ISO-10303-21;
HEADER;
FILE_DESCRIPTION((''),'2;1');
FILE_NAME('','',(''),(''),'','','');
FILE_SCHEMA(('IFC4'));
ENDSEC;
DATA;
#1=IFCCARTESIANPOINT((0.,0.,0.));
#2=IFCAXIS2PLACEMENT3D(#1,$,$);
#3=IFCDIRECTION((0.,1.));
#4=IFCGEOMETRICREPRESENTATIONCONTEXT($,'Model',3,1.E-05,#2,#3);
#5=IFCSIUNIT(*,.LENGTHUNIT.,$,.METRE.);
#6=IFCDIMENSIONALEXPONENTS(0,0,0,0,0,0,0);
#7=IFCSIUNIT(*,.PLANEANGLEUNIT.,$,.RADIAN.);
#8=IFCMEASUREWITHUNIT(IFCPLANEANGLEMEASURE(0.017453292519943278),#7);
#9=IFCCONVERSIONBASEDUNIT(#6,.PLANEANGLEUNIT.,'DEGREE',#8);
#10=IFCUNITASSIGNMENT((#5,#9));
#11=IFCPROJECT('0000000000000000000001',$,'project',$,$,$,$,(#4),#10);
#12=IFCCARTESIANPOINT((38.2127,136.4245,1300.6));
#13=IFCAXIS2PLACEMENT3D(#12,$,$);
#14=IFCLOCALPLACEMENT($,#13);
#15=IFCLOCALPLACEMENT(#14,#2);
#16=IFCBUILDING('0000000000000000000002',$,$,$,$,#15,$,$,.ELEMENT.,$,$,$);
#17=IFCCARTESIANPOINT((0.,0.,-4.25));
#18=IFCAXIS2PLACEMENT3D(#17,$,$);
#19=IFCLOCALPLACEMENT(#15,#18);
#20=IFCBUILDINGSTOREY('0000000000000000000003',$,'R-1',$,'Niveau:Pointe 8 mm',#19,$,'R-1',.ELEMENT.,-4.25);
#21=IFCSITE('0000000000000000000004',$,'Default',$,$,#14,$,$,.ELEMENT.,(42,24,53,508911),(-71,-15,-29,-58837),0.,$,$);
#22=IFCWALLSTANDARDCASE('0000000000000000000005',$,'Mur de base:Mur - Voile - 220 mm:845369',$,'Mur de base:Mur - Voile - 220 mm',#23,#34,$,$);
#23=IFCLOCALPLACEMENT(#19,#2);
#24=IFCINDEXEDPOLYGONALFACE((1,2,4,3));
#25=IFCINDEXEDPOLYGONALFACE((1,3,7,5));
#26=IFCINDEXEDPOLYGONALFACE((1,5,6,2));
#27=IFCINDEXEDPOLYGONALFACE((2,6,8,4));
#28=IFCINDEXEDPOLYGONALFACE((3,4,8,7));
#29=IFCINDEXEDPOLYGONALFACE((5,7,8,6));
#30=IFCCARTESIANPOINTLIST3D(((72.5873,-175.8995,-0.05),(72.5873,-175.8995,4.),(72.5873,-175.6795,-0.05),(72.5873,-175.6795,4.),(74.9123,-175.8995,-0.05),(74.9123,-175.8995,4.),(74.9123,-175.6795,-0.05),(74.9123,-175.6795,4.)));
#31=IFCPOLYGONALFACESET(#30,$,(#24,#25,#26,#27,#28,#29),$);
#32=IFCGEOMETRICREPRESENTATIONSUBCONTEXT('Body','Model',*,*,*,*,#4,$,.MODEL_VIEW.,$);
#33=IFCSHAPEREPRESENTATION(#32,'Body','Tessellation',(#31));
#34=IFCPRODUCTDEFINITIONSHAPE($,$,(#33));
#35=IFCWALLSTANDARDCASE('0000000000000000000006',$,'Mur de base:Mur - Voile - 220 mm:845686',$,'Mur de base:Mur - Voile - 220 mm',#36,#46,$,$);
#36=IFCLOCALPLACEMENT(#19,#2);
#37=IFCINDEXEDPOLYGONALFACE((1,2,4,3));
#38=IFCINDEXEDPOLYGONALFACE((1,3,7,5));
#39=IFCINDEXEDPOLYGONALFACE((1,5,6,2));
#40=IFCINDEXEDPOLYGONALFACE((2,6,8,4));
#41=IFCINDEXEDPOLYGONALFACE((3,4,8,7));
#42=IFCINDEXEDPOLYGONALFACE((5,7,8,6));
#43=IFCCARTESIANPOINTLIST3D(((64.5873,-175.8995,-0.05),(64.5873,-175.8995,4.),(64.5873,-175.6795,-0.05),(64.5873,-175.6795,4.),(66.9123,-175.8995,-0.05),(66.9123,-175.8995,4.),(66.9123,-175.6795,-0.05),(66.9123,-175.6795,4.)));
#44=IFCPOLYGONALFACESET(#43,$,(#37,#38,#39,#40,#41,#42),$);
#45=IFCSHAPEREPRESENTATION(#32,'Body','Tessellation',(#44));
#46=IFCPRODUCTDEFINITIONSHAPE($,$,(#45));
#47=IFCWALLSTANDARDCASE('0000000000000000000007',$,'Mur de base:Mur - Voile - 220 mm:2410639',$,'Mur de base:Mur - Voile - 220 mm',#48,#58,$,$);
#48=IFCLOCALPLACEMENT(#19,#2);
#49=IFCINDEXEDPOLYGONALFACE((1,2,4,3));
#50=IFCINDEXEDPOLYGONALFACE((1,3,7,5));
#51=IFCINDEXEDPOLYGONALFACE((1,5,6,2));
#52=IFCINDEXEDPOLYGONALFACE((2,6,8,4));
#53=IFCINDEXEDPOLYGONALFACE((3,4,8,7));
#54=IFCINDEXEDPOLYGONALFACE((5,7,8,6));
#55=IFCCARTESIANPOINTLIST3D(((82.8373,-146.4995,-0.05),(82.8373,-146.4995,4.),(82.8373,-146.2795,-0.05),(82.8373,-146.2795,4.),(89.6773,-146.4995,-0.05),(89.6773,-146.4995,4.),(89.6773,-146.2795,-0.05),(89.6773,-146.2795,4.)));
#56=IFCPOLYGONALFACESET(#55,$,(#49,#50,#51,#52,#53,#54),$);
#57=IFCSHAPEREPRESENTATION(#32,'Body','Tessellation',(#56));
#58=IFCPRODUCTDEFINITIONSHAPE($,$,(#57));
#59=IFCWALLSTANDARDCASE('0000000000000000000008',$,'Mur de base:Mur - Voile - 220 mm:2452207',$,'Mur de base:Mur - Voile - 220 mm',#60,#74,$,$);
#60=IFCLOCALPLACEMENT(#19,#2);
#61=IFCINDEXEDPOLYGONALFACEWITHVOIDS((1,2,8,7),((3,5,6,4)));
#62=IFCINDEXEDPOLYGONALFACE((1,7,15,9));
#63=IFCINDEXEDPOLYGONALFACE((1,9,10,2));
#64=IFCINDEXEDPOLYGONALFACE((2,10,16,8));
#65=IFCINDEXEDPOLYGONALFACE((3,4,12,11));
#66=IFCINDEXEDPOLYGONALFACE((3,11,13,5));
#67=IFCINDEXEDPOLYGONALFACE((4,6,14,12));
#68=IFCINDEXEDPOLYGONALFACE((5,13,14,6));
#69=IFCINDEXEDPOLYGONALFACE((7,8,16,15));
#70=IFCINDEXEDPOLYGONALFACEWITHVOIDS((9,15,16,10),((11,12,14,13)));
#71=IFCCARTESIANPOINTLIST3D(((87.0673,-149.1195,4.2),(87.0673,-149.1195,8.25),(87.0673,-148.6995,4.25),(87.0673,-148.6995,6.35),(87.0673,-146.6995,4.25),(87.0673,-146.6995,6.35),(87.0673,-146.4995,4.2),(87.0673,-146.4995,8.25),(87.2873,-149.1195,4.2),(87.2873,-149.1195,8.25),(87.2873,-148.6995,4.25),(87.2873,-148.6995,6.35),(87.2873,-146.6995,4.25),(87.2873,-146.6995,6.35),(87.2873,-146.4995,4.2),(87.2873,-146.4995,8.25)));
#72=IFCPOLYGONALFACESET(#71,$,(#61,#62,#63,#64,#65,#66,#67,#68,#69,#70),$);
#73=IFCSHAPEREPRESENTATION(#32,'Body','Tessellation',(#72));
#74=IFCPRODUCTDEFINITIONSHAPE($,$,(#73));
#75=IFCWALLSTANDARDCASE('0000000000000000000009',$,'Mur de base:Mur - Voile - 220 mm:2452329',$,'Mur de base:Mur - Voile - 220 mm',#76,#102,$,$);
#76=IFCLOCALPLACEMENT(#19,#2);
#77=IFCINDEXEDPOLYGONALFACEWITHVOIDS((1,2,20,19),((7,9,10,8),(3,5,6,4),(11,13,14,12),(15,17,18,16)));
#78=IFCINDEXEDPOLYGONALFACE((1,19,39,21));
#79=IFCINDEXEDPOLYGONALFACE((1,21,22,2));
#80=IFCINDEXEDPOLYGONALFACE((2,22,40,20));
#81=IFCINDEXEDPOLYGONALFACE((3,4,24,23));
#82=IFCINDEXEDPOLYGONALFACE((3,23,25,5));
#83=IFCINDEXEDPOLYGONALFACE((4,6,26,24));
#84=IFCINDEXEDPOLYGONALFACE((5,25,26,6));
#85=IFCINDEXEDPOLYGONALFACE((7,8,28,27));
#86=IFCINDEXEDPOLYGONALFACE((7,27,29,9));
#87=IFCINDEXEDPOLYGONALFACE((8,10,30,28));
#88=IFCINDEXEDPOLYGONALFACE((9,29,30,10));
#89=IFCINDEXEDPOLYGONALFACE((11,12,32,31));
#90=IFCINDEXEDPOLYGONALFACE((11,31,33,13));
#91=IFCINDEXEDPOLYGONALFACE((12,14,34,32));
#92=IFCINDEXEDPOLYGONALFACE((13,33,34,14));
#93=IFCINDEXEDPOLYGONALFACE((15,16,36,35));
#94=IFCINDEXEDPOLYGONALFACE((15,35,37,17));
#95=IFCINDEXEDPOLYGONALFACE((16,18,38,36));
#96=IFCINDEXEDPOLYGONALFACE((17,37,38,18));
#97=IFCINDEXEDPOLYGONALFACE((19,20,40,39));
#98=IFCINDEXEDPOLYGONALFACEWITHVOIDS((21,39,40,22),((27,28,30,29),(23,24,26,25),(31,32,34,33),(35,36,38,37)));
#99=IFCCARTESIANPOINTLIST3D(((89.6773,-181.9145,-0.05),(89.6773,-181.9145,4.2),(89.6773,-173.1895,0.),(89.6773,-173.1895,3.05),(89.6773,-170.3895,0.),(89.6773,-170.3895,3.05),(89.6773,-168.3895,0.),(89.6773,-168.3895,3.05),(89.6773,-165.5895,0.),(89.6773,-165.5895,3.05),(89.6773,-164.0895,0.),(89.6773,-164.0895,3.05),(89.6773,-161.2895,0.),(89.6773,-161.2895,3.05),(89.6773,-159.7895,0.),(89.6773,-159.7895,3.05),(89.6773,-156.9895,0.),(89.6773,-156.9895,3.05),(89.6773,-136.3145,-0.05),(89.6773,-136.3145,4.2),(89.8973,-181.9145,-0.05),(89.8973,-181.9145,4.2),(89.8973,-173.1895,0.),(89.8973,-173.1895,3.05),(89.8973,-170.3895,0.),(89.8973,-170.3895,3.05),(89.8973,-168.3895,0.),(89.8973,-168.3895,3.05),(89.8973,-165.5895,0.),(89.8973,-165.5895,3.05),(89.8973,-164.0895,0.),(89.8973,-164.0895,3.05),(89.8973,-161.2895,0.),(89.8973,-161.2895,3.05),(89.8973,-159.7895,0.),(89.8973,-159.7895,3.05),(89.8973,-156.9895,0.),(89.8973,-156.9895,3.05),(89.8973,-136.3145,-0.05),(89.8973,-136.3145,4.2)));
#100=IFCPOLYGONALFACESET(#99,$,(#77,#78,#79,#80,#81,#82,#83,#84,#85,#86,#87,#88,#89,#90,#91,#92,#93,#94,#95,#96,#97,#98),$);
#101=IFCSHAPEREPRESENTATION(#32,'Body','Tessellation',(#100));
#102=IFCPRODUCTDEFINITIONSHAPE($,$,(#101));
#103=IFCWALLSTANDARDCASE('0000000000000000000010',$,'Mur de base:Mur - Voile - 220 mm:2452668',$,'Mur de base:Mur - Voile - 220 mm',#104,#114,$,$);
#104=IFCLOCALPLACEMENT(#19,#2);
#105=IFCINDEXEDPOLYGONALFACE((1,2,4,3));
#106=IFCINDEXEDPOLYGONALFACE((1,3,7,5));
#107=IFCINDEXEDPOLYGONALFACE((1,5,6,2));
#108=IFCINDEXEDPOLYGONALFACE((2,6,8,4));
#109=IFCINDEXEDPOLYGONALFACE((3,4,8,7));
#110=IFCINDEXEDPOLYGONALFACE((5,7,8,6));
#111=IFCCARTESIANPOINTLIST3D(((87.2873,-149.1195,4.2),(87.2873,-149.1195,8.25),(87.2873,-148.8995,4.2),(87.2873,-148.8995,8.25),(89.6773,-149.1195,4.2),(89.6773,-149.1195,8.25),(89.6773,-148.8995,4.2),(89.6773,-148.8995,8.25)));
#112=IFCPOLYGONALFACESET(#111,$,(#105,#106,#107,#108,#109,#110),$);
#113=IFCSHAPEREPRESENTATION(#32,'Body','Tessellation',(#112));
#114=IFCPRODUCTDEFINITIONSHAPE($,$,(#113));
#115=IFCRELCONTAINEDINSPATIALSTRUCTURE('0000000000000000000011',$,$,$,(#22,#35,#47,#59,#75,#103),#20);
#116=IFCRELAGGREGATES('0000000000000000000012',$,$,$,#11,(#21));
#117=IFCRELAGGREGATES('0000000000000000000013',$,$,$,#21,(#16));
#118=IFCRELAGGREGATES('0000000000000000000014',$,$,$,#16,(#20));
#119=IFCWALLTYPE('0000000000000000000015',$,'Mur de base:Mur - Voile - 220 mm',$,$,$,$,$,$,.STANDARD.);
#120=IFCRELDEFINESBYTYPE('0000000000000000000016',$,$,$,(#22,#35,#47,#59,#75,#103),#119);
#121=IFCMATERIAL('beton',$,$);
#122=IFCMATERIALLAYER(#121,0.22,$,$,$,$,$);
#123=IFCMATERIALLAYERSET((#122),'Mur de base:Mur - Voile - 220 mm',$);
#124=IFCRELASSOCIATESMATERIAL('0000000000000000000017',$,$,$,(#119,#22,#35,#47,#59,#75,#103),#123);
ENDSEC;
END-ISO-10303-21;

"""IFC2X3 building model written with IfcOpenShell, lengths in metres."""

from ifc_helpers import new_model, entity, si_unit, converted_unit, direction, frame, frame_2d, origin, place, context, subcontext, project, spatial, polyline, rectangle, extrude, clip, bounded_halfspace, material, layer, layer_set, layer_usage, type_object, element, save


model = new_model("IFC2X3")

# Units and contexts
model_context = context("Model", 3, precision=1e-05, world=origin(), true_north=direction((0.0, 1.0)))
body_context = subcontext(model_context, "Body", "Model", "MODEL_VIEW")
ifc_project = project(units=[si_unit("LENGTHUNIT", "METRE"), converted_unit("PLANEANGLEUNIT", "DEGREE", entity("IfcPlaneAngleMeasure", 0.017453292519943278), si_unit("PLANEANGLEUNIT", "RADIAN"), dimensions=[0, 0, 0, 0, 0, 0, 0])], contexts=[model_context])

# Site, building, storey
site_placement = place(None, frame((38.2127, 136.4245, 1300.6)))
site = spatial("IfcSite", under=ifc_project, at=site_placement, Name="Default", CompositionType="ELEMENT", RefLatitude=(42, 24, 53, 508911), RefLongitude=(-71, -15, -29, -58837), RefElevation=0.0)
building_placement = place(site_placement, origin())
building = spatial("IfcBuilding", under=site, at=building_placement, CompositionType="ELEMENT")
storey_placement = place(building_placement, frame((0.0, 0.0, -4.25)))
storey = spatial("IfcBuildingStorey", under=building, at=storey_placement, Name="R-1", ObjectType="Niveau:Pointe 8 mm", LongName="R-1", CompositionType="ELEMENT", Elevation=-4.25)

# Walls
ifc_material_1 = material(Name="beton")
ifc_layer = layer(ifc_material_1, 0.22)
ifc_layer_set = layer_set([ifc_layer], Name="Mur de base:Mur - Voile - 220 mm")
wall_type = type_object("IfcWallType", Name="Mur de base:Mur - Voile - 220 mm", PredefinedType="STANDARD", material=ifc_layer_set)
ifc_layer_usage_1 = layer_usage(ifc_layer_set, "AXIS2", "NEGATIVE", 0.11)
wall_1_placement = place(storey_placement, frame((72.5873, -175.7895, -0.05)))
element("IfcWallStandardCase", 1, at=wall_1_placement, inside=storey, type_object=wall_type, material=ifc_layer_usage_1, Name="Mur de base:Mur - Voile - 220 mm:845369", ObjectType="Mur de base:Mur - Voile - 220 mm", context=body_context, shape_type="SweptSolid", body=[
    extrude(rectangle(XDim=2.325, YDim=0.22, at=frame_2d((1.1625, 0.0), x_axis=(-1.0, 0.0))), origin(), (0.0, 0.0, 1.0), 4.05),
])
ifc_layer_usage_2 = layer_usage(ifc_layer_set, "AXIS2", "NEGATIVE", 0.11)
wall_2_placement = place(storey_placement, frame((64.5873, -175.7895, -0.05)))
element("IfcWallStandardCase", 2, at=wall_2_placement, inside=storey, type_object=wall_type, material=ifc_layer_usage_2, Name="Mur de base:Mur - Voile - 220 mm:845686", ObjectType="Mur de base:Mur - Voile - 220 mm", context=body_context, shape_type="SweptSolid", body=[
    extrude(rectangle(XDim=2.325, YDim=0.22, at=frame_2d((1.1625, 0.0), x_axis=(-1.0, 0.0))), origin(), (0.0, 0.0, 1.0), 4.05),
])
ifc_layer_usage_3 = layer_usage(ifc_layer_set, "AXIS2", "NEGATIVE", 0.11)
wall_3_placement = place(storey_placement, frame((82.8373, -146.3895, -0.05)))
element("IfcWallStandardCase", 3, at=wall_3_placement, inside=storey, type_object=wall_type, material=ifc_layer_usage_3, Name="Mur de base:Mur - Voile - 220 mm:2410639", ObjectType="Mur de base:Mur - Voile - 220 mm", context=body_context, shape_type="Clipping", body=[
    clip(extrude(rectangle(XDim=6.84, YDim=0.22, at=frame_2d((3.42, 0.0), x_axis=(-1.0, 0.0))), origin(), (0.0, 0.0, 1.0), 4.05), bounded_halfspace(frame((0.0, -0.11, 4.05), z_axis=(0.0, 0.0, -1.0), x_axis=(0.0, -1.0, 0.0)), True, frame((0.0, -0.11, 4.05)), polyline([(0.0, 0.0), (4.23, 0.0), (4.45, 0.0), (6.84, 0.0), (6.84, 0.22), (0.0, 0.22), (0.0, 0.0)]))),
])

# Wall, opening
ifc_layer_usage_4 = layer_usage(ifc_layer_set, "AXIS2", "NEGATIVE", 0.11)
wall_4_placement = place(storey_placement, frame((87.1773, -146.4995, 4.2), z_axis=(0.0, 0.0, 1.0), x_axis=(0.0, -1.0, 0.0)))
wall_4 = element("IfcWallStandardCase", 4, at=wall_4_placement, inside=storey, type_object=wall_type, material=ifc_layer_usage_4, Name="Mur de base:Mur - Voile - 220 mm:2452207", ObjectType="Mur de base:Mur - Voile - 220 mm", context=body_context, shape_type="SweptSolid", body=[
    extrude(rectangle(XDim=2.62, YDim=0.22, at=frame_2d((1.31, 0.0), x_axis=(-1.0, 0.0))), origin(), (0.0, 0.0, 1.0), 4.05),
])
opening_1_placement = place(wall_4_placement, frame((-146.4995, -87.1773, 0.05), z_axis=(0.0, 0.0, 1.0), x_axis=(0.0, 1.0, 0.0)))
element("IfcOpeningElement", 5, at=opening_1_placement, cuts=wall_4, ObjectType="Opening", context=body_context, shape_type="SweptSolid", body=[
    extrude(rectangle(XDim=2.1, YDim=2.0, at=frame_2d((0.0, 0.0), x_axis=(0.0, 1.0))), frame((85.5433, -147.6995, 1.05), z_axis=(1.0, 0.0, 0.0), x_axis=(0.0, -1.0, 0.0)), (0.0, 0.0, 1.0), 3.048),
])

# Wall, openings
ifc_layer_usage_5 = layer_usage(ifc_layer_set, "AXIS2", "NEGATIVE", 0.11)
wall_5_placement = place(storey_placement, frame((89.7873, -181.9145, -0.05), z_axis=(0.0, 0.0, 1.0), x_axis=(0.0, 1.0, 0.0)))
wall_5 = element("IfcWallStandardCase", 6, at=wall_5_placement, inside=storey, type_object=wall_type, material=ifc_layer_usage_5, Name="Mur de base:Mur - Voile - 220 mm:2452329", ObjectType="Mur de base:Mur - Voile - 220 mm", context=body_context, shape_type="SweptSolid", body=[
    extrude(rectangle(XDim=45.6, YDim=0.22, at=frame_2d((22.8, 0.0), x_axis=(-1.0, 0.0))), origin(), (0.0, 0.0, 1.0), 4.25),
])
opening_2_placement = place(wall_5_placement, origin())
element("IfcOpeningElement", 7, at=opening_2_placement, cuts=wall_5, ObjectType="Opening", context=body_context, shape_type="SweptSolid", body=[
    extrude(rectangle(XDim=3.05, YDim=2.8, at=frame_2d((0.0, 0.0), x_axis=(0.0, 1.0))), frame((10.125, 0.11, 1.575), z_axis=(0.0, -1.0, 0.0), x_axis=(-1.0, 0.0, 0.0)), (0.0, 0.0, 1.0), 0.22),
])
opening_3_placement = place(wall_5_placement, origin())
element("IfcOpeningElement", 8, at=opening_3_placement, cuts=wall_5, ObjectType="Opening", context=body_context, shape_type="SweptSolid", body=[
    extrude(rectangle(XDim=3.05, YDim=2.8, at=frame_2d((0.0, 0.0), x_axis=(0.0, 1.0))), frame((14.925, 0.11, 1.575), z_axis=(0.0, -1.0, 0.0), x_axis=(-1.0, 0.0, 0.0)), (0.0, 0.0, 1.0), 0.22),
])
opening_4_placement = place(wall_5_placement, origin())
element("IfcOpeningElement", 9, at=opening_4_placement, cuts=wall_5, ObjectType="Opening", context=body_context, shape_type="SweptSolid", body=[
    extrude(rectangle(XDim=3.05, YDim=2.8, at=frame_2d((0.0, 0.0), x_axis=(0.0, 1.0))), frame((19.225, 0.11, 1.575), z_axis=(0.0, -1.0, 0.0), x_axis=(-1.0, 0.0, 0.0)), (0.0, 0.0, 1.0), 0.22),
])
opening_5_placement = place(wall_5_placement, origin())
element("IfcOpeningElement", 10, at=opening_5_placement, cuts=wall_5, ObjectType="Opening", context=body_context, shape_type="SweptSolid", body=[
    extrude(rectangle(XDim=3.05, YDim=2.8, at=frame_2d((0.0, 0.0), x_axis=(0.0, 1.0))), frame((23.525, 0.11, 1.575), z_axis=(0.0, -1.0, 0.0), x_axis=(-1.0, 0.0, 0.0)), (0.0, 0.0, 1.0), 0.22),
])

# Wall
ifc_layer_usage_6 = layer_usage(ifc_layer_set, "AXIS2", "NEGATIVE", 0.11)
wall_6_placement = place(storey_placement, frame((87.2873, -149.0095, 4.2)))
element("IfcWallStandardCase", 11, at=wall_6_placement, inside=storey, type_object=wall_type, material=ifc_layer_usage_6, Name="Mur de base:Mur - Voile - 220 mm:2452668", ObjectType="Mur de base:Mur - Voile - 220 mm", context=body_context, shape_type="SweptSolid", body=[
    extrude(rectangle(XDim=2.39, YDim=0.22, at=frame_2d((1.195, 0.0), x_axis=(-1.0, 0.0))), origin(), (0.0, 0.0, 1.0), 4.05),
])

save(model, "model.ifc")
